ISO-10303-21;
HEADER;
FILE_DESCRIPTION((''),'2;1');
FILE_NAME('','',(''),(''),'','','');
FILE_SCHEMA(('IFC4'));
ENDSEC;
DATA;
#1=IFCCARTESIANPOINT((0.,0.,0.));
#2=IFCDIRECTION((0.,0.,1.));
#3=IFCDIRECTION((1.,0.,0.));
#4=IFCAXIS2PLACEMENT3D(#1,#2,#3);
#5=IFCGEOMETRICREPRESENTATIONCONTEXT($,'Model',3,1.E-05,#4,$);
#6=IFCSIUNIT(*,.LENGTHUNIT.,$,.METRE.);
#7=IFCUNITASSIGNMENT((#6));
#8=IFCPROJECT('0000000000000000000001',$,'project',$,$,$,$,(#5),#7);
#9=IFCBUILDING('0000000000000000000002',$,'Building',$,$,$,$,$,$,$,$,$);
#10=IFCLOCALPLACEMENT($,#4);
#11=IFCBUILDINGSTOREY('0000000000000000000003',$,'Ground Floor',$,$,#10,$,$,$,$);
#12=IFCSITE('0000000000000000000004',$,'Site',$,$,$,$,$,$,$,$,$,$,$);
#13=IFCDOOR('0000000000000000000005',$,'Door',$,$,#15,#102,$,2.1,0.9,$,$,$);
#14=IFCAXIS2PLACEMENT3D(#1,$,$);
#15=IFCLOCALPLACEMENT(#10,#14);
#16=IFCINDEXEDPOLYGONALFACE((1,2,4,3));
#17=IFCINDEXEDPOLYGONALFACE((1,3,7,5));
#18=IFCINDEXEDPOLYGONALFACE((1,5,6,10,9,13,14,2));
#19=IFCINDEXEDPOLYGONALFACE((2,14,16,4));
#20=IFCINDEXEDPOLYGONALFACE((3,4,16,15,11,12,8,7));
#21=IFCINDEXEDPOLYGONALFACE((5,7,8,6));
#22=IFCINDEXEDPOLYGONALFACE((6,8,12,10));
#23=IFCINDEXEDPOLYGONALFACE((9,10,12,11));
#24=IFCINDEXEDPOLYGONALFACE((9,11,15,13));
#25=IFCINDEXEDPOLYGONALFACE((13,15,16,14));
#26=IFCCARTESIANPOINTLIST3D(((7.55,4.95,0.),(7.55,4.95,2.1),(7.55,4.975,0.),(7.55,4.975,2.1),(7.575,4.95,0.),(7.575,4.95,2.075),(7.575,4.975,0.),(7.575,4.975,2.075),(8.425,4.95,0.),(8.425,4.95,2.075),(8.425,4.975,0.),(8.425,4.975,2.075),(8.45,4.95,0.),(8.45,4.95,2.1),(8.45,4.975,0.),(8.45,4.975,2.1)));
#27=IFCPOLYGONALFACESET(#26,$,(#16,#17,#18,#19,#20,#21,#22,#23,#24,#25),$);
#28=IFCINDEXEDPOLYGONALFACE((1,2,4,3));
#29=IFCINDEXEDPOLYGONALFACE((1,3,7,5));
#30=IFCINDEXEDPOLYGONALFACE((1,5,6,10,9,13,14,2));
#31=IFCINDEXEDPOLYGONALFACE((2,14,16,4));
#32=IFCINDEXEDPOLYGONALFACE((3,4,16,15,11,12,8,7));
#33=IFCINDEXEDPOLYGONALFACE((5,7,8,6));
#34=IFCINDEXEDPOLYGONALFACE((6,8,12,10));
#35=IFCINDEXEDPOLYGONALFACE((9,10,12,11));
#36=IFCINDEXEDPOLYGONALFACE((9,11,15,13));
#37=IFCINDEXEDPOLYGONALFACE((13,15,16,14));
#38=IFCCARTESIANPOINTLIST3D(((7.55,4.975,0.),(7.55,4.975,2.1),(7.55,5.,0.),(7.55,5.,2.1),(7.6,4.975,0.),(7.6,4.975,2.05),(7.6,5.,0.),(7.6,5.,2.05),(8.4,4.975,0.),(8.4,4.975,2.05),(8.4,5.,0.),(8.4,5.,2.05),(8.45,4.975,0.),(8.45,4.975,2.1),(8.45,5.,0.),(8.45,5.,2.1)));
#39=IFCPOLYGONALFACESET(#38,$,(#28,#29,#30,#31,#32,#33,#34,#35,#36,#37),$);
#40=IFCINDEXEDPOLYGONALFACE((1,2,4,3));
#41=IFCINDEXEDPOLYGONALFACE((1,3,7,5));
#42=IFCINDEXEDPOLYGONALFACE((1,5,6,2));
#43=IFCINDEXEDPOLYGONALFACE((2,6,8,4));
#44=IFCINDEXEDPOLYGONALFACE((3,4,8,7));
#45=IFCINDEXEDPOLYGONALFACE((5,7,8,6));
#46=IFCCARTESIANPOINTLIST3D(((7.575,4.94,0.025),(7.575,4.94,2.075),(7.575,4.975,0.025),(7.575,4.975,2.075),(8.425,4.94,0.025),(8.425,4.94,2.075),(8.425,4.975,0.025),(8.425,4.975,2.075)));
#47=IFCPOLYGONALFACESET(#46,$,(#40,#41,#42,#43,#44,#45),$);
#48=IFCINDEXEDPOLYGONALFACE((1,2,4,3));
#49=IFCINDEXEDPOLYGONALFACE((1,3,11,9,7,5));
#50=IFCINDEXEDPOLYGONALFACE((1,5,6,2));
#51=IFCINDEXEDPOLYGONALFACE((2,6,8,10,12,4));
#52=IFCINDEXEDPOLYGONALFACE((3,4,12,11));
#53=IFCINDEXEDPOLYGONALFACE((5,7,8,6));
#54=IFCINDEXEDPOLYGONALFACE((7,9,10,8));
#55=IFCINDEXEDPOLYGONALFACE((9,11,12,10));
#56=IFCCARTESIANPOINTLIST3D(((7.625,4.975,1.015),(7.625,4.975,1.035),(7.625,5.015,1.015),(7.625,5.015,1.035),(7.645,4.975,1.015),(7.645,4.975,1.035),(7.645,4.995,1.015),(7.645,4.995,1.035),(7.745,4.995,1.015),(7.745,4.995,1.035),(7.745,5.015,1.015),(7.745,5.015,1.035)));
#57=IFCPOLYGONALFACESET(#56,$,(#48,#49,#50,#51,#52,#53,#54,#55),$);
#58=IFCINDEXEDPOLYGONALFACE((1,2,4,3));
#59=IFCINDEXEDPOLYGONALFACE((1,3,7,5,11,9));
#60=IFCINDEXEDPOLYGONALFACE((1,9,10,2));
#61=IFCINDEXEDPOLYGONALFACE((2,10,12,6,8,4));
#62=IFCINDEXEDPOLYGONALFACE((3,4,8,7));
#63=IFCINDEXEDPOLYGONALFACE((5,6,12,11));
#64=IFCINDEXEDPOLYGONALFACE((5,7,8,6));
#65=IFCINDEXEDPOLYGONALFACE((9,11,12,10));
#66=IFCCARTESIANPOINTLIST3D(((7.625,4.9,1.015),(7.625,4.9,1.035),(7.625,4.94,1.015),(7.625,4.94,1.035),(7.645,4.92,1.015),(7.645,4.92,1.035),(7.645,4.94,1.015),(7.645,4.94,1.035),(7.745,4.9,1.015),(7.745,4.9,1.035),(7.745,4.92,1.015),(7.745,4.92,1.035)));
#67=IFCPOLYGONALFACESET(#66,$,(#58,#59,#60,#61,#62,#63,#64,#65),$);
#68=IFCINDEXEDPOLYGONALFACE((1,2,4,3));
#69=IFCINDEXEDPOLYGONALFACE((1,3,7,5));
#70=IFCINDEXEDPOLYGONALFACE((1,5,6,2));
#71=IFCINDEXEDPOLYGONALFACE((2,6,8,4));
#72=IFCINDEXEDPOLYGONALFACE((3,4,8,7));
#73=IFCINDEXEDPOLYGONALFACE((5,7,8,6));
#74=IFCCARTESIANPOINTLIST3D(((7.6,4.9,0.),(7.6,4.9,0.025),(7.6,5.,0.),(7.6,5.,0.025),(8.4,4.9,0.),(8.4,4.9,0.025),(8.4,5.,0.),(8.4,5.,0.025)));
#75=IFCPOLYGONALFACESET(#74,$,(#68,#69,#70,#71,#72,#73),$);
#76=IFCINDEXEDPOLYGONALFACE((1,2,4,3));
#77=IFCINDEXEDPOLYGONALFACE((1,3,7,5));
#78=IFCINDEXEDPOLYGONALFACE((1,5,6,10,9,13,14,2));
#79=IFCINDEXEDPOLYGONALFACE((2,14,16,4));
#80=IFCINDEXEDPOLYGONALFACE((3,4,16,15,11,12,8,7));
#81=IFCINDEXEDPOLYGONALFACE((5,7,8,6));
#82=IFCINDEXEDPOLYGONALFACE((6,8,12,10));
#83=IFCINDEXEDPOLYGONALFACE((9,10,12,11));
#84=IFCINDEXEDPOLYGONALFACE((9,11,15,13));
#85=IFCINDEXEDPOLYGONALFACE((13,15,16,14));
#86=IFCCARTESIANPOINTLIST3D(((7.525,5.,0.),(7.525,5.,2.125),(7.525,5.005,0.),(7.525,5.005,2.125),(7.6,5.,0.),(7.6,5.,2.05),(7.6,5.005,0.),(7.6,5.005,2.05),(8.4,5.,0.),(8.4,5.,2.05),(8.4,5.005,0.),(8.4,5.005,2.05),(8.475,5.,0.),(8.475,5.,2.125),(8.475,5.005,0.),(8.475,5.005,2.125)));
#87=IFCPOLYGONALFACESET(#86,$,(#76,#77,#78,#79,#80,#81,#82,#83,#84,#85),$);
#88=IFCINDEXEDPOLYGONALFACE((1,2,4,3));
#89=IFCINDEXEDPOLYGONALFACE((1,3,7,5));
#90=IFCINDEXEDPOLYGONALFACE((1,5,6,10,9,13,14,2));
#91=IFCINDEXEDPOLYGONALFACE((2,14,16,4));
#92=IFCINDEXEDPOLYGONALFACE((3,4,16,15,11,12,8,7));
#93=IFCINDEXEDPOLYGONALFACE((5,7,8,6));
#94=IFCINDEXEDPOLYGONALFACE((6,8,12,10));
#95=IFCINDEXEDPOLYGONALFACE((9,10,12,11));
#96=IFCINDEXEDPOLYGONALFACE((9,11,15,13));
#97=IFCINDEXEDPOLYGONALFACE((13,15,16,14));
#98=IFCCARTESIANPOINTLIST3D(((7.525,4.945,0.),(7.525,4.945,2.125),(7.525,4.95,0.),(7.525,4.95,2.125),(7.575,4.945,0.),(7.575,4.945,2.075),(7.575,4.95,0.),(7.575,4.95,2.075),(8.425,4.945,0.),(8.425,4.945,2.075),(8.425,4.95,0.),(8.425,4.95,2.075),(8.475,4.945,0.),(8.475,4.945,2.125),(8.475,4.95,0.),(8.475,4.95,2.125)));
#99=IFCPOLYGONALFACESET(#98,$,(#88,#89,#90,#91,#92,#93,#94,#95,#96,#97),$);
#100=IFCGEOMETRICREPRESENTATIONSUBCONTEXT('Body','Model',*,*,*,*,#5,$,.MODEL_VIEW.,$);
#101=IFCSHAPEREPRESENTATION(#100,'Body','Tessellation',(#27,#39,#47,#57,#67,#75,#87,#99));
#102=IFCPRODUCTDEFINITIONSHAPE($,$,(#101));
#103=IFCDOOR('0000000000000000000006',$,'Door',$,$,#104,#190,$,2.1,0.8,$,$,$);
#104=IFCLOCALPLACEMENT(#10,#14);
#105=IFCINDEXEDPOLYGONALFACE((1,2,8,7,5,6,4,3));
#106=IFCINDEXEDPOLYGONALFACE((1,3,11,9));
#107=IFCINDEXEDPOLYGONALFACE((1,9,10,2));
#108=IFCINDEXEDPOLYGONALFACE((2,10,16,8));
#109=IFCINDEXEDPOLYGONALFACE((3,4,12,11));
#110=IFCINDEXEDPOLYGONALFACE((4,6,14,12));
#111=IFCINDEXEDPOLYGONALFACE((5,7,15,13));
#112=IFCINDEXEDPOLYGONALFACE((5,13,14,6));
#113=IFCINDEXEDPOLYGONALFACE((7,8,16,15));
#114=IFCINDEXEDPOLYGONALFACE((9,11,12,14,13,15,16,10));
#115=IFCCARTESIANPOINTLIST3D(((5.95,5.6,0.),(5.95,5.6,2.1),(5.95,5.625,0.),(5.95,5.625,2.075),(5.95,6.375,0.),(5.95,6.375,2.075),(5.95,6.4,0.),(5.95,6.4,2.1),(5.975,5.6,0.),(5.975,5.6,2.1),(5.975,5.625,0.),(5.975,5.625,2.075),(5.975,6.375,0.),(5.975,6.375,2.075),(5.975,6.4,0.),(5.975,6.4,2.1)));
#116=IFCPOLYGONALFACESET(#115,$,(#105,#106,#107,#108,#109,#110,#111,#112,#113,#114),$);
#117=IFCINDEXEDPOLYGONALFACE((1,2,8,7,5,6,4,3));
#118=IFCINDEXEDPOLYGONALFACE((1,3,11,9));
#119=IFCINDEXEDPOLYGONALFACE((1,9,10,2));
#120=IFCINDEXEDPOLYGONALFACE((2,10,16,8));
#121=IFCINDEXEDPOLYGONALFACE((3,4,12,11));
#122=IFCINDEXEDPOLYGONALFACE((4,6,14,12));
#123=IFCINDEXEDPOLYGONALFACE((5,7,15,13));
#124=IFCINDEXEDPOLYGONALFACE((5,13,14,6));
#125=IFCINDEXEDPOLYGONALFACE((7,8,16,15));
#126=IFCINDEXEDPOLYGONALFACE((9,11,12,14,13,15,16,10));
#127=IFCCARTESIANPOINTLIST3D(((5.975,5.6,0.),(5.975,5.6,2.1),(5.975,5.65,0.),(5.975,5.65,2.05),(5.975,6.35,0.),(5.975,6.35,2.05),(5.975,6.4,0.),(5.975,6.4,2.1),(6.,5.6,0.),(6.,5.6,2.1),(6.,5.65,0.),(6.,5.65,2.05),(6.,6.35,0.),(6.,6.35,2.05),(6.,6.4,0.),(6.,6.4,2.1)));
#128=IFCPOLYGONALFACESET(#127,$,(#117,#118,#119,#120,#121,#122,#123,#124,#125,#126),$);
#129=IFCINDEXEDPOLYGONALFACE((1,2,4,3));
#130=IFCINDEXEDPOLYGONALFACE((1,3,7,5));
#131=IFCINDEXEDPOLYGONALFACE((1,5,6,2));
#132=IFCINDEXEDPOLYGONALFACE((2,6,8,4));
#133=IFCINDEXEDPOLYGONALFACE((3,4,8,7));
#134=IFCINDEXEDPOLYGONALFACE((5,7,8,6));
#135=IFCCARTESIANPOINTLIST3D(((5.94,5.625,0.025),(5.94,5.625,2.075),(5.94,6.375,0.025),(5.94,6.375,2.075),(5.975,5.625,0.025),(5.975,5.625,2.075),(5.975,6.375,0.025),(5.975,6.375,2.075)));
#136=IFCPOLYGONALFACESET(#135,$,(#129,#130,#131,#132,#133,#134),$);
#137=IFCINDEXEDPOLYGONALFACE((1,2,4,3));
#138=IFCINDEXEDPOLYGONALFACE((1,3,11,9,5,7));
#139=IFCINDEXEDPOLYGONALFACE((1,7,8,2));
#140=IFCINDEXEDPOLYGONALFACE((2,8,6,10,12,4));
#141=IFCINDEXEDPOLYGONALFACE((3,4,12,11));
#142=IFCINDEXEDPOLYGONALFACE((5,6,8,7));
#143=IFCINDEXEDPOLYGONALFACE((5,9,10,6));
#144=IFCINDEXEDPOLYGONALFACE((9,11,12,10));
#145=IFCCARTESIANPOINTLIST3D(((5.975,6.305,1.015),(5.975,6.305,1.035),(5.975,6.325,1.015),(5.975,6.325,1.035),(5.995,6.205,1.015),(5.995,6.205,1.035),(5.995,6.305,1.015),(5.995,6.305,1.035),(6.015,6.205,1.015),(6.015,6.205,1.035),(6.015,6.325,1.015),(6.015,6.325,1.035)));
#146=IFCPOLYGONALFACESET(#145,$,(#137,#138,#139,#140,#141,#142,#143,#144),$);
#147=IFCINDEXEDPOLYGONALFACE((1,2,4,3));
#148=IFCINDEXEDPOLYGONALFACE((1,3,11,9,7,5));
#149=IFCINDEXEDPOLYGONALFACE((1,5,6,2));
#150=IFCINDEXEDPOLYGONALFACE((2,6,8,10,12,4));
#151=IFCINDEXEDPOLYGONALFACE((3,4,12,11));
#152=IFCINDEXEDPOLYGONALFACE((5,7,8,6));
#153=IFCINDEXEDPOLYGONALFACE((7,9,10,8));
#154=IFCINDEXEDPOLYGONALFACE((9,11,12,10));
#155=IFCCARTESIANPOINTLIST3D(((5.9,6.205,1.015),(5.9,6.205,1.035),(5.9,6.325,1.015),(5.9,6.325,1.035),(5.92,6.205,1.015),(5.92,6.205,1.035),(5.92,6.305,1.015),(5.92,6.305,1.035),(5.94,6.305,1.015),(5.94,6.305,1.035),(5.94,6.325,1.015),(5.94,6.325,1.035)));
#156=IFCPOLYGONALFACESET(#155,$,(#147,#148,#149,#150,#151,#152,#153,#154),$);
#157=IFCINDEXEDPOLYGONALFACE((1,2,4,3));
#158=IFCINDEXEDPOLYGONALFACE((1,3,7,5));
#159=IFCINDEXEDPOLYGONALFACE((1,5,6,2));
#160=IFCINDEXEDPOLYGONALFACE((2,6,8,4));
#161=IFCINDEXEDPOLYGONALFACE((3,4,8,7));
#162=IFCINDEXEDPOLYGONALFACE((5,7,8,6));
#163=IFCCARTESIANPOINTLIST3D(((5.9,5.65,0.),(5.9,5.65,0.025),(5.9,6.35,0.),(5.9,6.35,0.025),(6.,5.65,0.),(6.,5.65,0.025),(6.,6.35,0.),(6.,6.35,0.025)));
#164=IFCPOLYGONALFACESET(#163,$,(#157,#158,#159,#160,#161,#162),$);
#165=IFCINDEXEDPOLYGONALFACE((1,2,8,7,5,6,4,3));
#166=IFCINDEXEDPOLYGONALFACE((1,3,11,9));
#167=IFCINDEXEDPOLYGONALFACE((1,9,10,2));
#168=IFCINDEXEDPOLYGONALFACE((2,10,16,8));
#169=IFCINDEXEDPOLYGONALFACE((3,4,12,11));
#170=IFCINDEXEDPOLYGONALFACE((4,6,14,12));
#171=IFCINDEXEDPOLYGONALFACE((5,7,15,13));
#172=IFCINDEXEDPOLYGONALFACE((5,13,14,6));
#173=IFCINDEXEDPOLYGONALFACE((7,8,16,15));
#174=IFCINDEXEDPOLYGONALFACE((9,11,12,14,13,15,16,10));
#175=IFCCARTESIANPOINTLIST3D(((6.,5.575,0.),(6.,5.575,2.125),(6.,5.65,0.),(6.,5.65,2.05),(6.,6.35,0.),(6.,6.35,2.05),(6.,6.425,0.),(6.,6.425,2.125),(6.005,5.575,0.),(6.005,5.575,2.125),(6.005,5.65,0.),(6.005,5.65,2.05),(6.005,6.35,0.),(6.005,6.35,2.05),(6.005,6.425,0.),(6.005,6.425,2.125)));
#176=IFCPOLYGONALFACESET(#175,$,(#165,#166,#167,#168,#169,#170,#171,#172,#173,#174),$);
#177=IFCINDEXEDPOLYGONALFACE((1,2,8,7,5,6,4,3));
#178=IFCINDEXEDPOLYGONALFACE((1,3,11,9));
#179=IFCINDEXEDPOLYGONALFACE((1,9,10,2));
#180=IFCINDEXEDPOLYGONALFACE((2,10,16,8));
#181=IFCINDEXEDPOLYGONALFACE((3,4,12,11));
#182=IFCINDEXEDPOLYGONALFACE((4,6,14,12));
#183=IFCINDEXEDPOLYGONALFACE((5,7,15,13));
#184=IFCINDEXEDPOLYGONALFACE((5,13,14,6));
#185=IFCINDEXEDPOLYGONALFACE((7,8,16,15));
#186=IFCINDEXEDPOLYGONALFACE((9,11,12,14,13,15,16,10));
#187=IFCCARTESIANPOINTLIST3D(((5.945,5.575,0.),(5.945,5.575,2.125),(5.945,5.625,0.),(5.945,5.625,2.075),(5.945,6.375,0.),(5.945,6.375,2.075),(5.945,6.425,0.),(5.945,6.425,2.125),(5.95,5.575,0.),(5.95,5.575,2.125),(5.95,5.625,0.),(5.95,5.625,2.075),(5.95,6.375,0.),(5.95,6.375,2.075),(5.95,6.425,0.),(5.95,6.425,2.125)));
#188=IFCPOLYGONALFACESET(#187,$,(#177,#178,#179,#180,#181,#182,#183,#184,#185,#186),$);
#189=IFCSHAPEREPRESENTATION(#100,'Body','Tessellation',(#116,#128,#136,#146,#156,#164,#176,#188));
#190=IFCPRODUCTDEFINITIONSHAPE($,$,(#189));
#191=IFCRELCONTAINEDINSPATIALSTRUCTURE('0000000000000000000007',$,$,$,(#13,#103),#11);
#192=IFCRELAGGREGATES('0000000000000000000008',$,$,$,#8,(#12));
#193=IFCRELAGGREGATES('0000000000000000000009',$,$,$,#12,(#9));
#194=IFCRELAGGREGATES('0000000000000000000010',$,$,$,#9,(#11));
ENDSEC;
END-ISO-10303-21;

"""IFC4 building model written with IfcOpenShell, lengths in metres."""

from ifc_helpers import new_model, si_unit, frame, origin_with_axes, place, context, subcontext, project, spatial, line, indexed_curve, outline, extrude, element, save


model = new_model("IFC4")

# Units and contexts
model_context = context("Model", 3, precision=1e-05, world=origin_with_axes())
body_context = subcontext(model_context, "Body", "Model", "MODEL_VIEW")
ifc_project = project(units=[si_unit("LENGTHUNIT", "METRE")], contexts=[model_context])

# Site, building, storey
site = spatial("IfcSite", under=ifc_project, Name="Site")
building = spatial("IfcBuilding", under=site, Name="Building")
storey_placement = place(None, origin_with_axes())
storey = spatial("IfcBuildingStorey", under=building, at=storey_placement, Name="Ground Floor")

# Doors
door_1_placement = place(storey_placement, frame((8.45, 5.0, 0.0), z_axis=(0.0, 0.0, 1.0), x_axis=(-1.0, 0.0, 0.0)))
element("IfcDoor", 1, at=door_1_placement, inside=storey, Name="Door", OverallHeight=2.1, OverallWidth=0.9, context=body_context, shape_type="SweptSolid", body=[
    extrude(outline(indexed_curve([(0.0, 0.0), (0.0, 2.1), (0.9, 2.1), (0.9, 0.0), (0.875, 0.0), (0.875, 2.075), (0.025, 2.075), (0.025, 0.0)], segments=[line(1, 2, 3, 4, 5, 6, 7, 8, 1)])), frame((0.0, 0.025, 0.0), z_axis=(0.0, -1.0, 0.0), x_axis=(1.0, 0.0, 0.0)), (0.0, 0.0, -1.0), 0.025),
    extrude(outline(indexed_curve([(0.0, 0.0), (0.0, 2.1), (0.9, 2.1), (0.9, 0.0), (0.85, 0.0), (0.85, 2.05), (0.05, 2.05), (0.05, 0.0)], segments=[line(1, 2, 3, 4, 5, 6, 7, 8, 1)])), frame((0.0, 0.0, 0.0), z_axis=(0.0, -1.0, 0.0), x_axis=(1.0, 0.0, 0.0)), (0.0, 0.0, -1.0), 0.025),
    extrude(outline(indexed_curve([(0.0, 0.0), (0.85, 0.0), (0.85, 0.035), (0.0, 0.035)], segments=[line(1, 2, 3, 4, 1)])), frame((0.025, 0.025, 0.025), z_axis=(0.0, 0.0, 1.0), x_axis=(1.0, 0.0, 0.0)), (0.0, 0.0, 1.0), 2.05),
    extrude(outline(indexed_curve([(0.0, 0.0), (0.0, -0.04), (-0.12, -0.04), (-0.12, -0.02), (-0.02, -0.02), (-0.02, 0.0)], segments=[line(1, 2, 3, 4, 5, 6, 1)])), frame((0.825, 0.025, 1.015), z_axis=(0.0, 0.0, 1.0), x_axis=(1.0, 0.0, 0.0)), (0.0, 0.0, 1.0), 0.02),
    extrude(outline(indexed_curve([(0.0, 0.0), (0.0, 0.04), (-0.12, 0.04), (-0.12, 0.02), (-0.02, 0.02), (-0.02, 0.0)], segments=[line(1, 2, 3, 4, 5, 6, 1)])), frame((0.825, 0.06, 1.015), z_axis=(0.0, 0.0, 1.0), x_axis=(1.0, 0.0, 0.0)), (0.0, 0.0, 1.0), 0.02),
    extrude(outline(indexed_curve([(0.0, 0.0), (0.8, 0.0), (0.8, 0.1), (0.0, 0.1)], segments=[line(1, 2, 3, 4, 1)])), frame((0.05, 0.0, 0.0), z_axis=(0.0, 0.0, 1.0), x_axis=(1.0, 0.0, 0.0)), (0.0, 0.0, 1.0), 0.025),
    extrude(outline(indexed_curve([(0.0, 0.0), (0.0, 2.125), (0.95, 2.125), (0.95, 0.0), (0.875, 0.0), (0.875, 2.05), (0.075, 2.05), (0.075, 0.0)], segments=[line(1, 2, 3, 4, 5, 6, 7, 8, 1)])), frame((-0.025, -0.005, 0.0), z_axis=(0.0, -1.0, 0.0), x_axis=(1.0, 0.0, 0.0)), (0.0, 0.0, -1.0), 0.005),
    extrude(outline(indexed_curve([(0.0, 0.0), (0.0, 2.125), (0.95, 2.125), (0.95, 0.0), (0.9, 0.0), (0.9, 2.075), (0.05, 2.075), (0.05, 0.0)], segments=[line(1, 2, 3, 4, 5, 6, 7, 8, 1)])), frame((-0.025, 0.05, 0.0), z_axis=(0.0, -1.0, 0.0), x_axis=(1.0, 0.0, 0.0)), (0.0, 0.0, -1.0), 0.005),
])
door_2_placement = place(storey_placement, frame((6.0, 5.6, 0.0), z_axis=(0.0, 0.0, 1.0), x_axis=(0.0, 1.0, 0.0)))
element("IfcDoor", 2, at=door_2_placement, inside=storey, Name="Door", OverallHeight=2.1, OverallWidth=0.8, context=body_context, shape_type="SweptSolid", body=[
    extrude(outline(indexed_curve([(0.0, 0.0), (0.0, 2.1), (0.8, 2.1), (0.8, 0.0), (0.775, 0.0), (0.775, 2.075), (0.025, 2.075), (0.025, 0.0)], segments=[line(1, 2, 3, 4, 5, 6, 7, 8, 1)])), frame((0.0, 0.025, 0.0), z_axis=(0.0, -1.0, 0.0), x_axis=(1.0, 0.0, 0.0)), (0.0, 0.0, -1.0), 0.025),
    extrude(outline(indexed_curve([(0.0, 0.0), (0.0, 2.1), (0.8, 2.1), (0.8, 0.0), (0.75, 0.0), (0.75, 2.05), (0.05, 2.05), (0.05, 0.0)], segments=[line(1, 2, 3, 4, 5, 6, 7, 8, 1)])), frame((0.0, 0.0, 0.0), z_axis=(0.0, -1.0, 0.0), x_axis=(1.0, 0.0, 0.0)), (0.0, 0.0, -1.0), 0.025),
    extrude(outline(indexed_curve([(0.0, 0.0), (0.75, 0.0), (0.75, 0.035), (0.0, 0.035)], segments=[line(1, 2, 3, 4, 1)])), frame((0.025, 0.025, 0.025), z_axis=(0.0, 0.0, 1.0), x_axis=(1.0, 0.0, 0.0)), (0.0, 0.0, 1.0), 2.05),
    extrude(outline(indexed_curve([(0.0, 0.0), (0.0, -0.04), (-0.12, -0.04), (-0.12, -0.02), (-0.02, -0.02), (-0.02, 0.0)], segments=[line(1, 2, 3, 4, 5, 6, 1)])), frame((0.725, 0.025, 1.015), z_axis=(0.0, 0.0, 1.0), x_axis=(1.0, 0.0, 0.0)), (0.0, 0.0, 1.0), 0.02),
    extrude(outline(indexed_curve([(0.0, 0.0), (0.0, 0.04), (-0.12, 0.04), (-0.12, 0.02), (-0.02, 0.02), (-0.02, 0.0)], segments=[line(1, 2, 3, 4, 5, 6, 1)])), frame((0.725, 0.06, 1.015), z_axis=(0.0, 0.0, 1.0), x_axis=(1.0, 0.0, 0.0)), (0.0, 0.0, 1.0), 0.02),
    extrude(outline(indexed_curve([(0.0, 0.0), (0.7, 0.0), (0.7, 0.1), (0.0, 0.1)], segments=[line(1, 2, 3, 4, 1)])), frame((0.05, 0.0, 0.0), z_axis=(0.0, 0.0, 1.0), x_axis=(1.0, 0.0, 0.0)), (0.0, 0.0, 1.0), 0.025),
    extrude(outline(indexed_curve([(0.0, 0.0), (0.0, 2.125), (0.85, 2.125), (0.85, 0.0), (0.775, 0.0), (0.775, 2.05), (0.075, 2.05), (0.075, 0.0)], segments=[line(1, 2, 3, 4, 5, 6, 7, 8, 1)])), frame((-0.025, -0.005, 0.0), z_axis=(0.0, -1.0, 0.0), x_axis=(1.0, 0.0, 0.0)), (0.0, 0.0, -1.0), 0.005),
    extrude(outline(indexed_curve([(0.0, 0.0), (0.0, 2.125), (0.85, 2.125), (0.85, 0.0), (0.8, 0.0), (0.8, 2.075), (0.05, 2.075), (0.05, 0.0)], segments=[line(1, 2, 3, 4, 5, 6, 7, 8, 1)])), frame((-0.025, 0.05, 0.0), z_axis=(0.0, -1.0, 0.0), x_axis=(1.0, 0.0, 0.0)), (0.0, 0.0, -1.0), 0.005),
])

save(model, "model.ifc")
